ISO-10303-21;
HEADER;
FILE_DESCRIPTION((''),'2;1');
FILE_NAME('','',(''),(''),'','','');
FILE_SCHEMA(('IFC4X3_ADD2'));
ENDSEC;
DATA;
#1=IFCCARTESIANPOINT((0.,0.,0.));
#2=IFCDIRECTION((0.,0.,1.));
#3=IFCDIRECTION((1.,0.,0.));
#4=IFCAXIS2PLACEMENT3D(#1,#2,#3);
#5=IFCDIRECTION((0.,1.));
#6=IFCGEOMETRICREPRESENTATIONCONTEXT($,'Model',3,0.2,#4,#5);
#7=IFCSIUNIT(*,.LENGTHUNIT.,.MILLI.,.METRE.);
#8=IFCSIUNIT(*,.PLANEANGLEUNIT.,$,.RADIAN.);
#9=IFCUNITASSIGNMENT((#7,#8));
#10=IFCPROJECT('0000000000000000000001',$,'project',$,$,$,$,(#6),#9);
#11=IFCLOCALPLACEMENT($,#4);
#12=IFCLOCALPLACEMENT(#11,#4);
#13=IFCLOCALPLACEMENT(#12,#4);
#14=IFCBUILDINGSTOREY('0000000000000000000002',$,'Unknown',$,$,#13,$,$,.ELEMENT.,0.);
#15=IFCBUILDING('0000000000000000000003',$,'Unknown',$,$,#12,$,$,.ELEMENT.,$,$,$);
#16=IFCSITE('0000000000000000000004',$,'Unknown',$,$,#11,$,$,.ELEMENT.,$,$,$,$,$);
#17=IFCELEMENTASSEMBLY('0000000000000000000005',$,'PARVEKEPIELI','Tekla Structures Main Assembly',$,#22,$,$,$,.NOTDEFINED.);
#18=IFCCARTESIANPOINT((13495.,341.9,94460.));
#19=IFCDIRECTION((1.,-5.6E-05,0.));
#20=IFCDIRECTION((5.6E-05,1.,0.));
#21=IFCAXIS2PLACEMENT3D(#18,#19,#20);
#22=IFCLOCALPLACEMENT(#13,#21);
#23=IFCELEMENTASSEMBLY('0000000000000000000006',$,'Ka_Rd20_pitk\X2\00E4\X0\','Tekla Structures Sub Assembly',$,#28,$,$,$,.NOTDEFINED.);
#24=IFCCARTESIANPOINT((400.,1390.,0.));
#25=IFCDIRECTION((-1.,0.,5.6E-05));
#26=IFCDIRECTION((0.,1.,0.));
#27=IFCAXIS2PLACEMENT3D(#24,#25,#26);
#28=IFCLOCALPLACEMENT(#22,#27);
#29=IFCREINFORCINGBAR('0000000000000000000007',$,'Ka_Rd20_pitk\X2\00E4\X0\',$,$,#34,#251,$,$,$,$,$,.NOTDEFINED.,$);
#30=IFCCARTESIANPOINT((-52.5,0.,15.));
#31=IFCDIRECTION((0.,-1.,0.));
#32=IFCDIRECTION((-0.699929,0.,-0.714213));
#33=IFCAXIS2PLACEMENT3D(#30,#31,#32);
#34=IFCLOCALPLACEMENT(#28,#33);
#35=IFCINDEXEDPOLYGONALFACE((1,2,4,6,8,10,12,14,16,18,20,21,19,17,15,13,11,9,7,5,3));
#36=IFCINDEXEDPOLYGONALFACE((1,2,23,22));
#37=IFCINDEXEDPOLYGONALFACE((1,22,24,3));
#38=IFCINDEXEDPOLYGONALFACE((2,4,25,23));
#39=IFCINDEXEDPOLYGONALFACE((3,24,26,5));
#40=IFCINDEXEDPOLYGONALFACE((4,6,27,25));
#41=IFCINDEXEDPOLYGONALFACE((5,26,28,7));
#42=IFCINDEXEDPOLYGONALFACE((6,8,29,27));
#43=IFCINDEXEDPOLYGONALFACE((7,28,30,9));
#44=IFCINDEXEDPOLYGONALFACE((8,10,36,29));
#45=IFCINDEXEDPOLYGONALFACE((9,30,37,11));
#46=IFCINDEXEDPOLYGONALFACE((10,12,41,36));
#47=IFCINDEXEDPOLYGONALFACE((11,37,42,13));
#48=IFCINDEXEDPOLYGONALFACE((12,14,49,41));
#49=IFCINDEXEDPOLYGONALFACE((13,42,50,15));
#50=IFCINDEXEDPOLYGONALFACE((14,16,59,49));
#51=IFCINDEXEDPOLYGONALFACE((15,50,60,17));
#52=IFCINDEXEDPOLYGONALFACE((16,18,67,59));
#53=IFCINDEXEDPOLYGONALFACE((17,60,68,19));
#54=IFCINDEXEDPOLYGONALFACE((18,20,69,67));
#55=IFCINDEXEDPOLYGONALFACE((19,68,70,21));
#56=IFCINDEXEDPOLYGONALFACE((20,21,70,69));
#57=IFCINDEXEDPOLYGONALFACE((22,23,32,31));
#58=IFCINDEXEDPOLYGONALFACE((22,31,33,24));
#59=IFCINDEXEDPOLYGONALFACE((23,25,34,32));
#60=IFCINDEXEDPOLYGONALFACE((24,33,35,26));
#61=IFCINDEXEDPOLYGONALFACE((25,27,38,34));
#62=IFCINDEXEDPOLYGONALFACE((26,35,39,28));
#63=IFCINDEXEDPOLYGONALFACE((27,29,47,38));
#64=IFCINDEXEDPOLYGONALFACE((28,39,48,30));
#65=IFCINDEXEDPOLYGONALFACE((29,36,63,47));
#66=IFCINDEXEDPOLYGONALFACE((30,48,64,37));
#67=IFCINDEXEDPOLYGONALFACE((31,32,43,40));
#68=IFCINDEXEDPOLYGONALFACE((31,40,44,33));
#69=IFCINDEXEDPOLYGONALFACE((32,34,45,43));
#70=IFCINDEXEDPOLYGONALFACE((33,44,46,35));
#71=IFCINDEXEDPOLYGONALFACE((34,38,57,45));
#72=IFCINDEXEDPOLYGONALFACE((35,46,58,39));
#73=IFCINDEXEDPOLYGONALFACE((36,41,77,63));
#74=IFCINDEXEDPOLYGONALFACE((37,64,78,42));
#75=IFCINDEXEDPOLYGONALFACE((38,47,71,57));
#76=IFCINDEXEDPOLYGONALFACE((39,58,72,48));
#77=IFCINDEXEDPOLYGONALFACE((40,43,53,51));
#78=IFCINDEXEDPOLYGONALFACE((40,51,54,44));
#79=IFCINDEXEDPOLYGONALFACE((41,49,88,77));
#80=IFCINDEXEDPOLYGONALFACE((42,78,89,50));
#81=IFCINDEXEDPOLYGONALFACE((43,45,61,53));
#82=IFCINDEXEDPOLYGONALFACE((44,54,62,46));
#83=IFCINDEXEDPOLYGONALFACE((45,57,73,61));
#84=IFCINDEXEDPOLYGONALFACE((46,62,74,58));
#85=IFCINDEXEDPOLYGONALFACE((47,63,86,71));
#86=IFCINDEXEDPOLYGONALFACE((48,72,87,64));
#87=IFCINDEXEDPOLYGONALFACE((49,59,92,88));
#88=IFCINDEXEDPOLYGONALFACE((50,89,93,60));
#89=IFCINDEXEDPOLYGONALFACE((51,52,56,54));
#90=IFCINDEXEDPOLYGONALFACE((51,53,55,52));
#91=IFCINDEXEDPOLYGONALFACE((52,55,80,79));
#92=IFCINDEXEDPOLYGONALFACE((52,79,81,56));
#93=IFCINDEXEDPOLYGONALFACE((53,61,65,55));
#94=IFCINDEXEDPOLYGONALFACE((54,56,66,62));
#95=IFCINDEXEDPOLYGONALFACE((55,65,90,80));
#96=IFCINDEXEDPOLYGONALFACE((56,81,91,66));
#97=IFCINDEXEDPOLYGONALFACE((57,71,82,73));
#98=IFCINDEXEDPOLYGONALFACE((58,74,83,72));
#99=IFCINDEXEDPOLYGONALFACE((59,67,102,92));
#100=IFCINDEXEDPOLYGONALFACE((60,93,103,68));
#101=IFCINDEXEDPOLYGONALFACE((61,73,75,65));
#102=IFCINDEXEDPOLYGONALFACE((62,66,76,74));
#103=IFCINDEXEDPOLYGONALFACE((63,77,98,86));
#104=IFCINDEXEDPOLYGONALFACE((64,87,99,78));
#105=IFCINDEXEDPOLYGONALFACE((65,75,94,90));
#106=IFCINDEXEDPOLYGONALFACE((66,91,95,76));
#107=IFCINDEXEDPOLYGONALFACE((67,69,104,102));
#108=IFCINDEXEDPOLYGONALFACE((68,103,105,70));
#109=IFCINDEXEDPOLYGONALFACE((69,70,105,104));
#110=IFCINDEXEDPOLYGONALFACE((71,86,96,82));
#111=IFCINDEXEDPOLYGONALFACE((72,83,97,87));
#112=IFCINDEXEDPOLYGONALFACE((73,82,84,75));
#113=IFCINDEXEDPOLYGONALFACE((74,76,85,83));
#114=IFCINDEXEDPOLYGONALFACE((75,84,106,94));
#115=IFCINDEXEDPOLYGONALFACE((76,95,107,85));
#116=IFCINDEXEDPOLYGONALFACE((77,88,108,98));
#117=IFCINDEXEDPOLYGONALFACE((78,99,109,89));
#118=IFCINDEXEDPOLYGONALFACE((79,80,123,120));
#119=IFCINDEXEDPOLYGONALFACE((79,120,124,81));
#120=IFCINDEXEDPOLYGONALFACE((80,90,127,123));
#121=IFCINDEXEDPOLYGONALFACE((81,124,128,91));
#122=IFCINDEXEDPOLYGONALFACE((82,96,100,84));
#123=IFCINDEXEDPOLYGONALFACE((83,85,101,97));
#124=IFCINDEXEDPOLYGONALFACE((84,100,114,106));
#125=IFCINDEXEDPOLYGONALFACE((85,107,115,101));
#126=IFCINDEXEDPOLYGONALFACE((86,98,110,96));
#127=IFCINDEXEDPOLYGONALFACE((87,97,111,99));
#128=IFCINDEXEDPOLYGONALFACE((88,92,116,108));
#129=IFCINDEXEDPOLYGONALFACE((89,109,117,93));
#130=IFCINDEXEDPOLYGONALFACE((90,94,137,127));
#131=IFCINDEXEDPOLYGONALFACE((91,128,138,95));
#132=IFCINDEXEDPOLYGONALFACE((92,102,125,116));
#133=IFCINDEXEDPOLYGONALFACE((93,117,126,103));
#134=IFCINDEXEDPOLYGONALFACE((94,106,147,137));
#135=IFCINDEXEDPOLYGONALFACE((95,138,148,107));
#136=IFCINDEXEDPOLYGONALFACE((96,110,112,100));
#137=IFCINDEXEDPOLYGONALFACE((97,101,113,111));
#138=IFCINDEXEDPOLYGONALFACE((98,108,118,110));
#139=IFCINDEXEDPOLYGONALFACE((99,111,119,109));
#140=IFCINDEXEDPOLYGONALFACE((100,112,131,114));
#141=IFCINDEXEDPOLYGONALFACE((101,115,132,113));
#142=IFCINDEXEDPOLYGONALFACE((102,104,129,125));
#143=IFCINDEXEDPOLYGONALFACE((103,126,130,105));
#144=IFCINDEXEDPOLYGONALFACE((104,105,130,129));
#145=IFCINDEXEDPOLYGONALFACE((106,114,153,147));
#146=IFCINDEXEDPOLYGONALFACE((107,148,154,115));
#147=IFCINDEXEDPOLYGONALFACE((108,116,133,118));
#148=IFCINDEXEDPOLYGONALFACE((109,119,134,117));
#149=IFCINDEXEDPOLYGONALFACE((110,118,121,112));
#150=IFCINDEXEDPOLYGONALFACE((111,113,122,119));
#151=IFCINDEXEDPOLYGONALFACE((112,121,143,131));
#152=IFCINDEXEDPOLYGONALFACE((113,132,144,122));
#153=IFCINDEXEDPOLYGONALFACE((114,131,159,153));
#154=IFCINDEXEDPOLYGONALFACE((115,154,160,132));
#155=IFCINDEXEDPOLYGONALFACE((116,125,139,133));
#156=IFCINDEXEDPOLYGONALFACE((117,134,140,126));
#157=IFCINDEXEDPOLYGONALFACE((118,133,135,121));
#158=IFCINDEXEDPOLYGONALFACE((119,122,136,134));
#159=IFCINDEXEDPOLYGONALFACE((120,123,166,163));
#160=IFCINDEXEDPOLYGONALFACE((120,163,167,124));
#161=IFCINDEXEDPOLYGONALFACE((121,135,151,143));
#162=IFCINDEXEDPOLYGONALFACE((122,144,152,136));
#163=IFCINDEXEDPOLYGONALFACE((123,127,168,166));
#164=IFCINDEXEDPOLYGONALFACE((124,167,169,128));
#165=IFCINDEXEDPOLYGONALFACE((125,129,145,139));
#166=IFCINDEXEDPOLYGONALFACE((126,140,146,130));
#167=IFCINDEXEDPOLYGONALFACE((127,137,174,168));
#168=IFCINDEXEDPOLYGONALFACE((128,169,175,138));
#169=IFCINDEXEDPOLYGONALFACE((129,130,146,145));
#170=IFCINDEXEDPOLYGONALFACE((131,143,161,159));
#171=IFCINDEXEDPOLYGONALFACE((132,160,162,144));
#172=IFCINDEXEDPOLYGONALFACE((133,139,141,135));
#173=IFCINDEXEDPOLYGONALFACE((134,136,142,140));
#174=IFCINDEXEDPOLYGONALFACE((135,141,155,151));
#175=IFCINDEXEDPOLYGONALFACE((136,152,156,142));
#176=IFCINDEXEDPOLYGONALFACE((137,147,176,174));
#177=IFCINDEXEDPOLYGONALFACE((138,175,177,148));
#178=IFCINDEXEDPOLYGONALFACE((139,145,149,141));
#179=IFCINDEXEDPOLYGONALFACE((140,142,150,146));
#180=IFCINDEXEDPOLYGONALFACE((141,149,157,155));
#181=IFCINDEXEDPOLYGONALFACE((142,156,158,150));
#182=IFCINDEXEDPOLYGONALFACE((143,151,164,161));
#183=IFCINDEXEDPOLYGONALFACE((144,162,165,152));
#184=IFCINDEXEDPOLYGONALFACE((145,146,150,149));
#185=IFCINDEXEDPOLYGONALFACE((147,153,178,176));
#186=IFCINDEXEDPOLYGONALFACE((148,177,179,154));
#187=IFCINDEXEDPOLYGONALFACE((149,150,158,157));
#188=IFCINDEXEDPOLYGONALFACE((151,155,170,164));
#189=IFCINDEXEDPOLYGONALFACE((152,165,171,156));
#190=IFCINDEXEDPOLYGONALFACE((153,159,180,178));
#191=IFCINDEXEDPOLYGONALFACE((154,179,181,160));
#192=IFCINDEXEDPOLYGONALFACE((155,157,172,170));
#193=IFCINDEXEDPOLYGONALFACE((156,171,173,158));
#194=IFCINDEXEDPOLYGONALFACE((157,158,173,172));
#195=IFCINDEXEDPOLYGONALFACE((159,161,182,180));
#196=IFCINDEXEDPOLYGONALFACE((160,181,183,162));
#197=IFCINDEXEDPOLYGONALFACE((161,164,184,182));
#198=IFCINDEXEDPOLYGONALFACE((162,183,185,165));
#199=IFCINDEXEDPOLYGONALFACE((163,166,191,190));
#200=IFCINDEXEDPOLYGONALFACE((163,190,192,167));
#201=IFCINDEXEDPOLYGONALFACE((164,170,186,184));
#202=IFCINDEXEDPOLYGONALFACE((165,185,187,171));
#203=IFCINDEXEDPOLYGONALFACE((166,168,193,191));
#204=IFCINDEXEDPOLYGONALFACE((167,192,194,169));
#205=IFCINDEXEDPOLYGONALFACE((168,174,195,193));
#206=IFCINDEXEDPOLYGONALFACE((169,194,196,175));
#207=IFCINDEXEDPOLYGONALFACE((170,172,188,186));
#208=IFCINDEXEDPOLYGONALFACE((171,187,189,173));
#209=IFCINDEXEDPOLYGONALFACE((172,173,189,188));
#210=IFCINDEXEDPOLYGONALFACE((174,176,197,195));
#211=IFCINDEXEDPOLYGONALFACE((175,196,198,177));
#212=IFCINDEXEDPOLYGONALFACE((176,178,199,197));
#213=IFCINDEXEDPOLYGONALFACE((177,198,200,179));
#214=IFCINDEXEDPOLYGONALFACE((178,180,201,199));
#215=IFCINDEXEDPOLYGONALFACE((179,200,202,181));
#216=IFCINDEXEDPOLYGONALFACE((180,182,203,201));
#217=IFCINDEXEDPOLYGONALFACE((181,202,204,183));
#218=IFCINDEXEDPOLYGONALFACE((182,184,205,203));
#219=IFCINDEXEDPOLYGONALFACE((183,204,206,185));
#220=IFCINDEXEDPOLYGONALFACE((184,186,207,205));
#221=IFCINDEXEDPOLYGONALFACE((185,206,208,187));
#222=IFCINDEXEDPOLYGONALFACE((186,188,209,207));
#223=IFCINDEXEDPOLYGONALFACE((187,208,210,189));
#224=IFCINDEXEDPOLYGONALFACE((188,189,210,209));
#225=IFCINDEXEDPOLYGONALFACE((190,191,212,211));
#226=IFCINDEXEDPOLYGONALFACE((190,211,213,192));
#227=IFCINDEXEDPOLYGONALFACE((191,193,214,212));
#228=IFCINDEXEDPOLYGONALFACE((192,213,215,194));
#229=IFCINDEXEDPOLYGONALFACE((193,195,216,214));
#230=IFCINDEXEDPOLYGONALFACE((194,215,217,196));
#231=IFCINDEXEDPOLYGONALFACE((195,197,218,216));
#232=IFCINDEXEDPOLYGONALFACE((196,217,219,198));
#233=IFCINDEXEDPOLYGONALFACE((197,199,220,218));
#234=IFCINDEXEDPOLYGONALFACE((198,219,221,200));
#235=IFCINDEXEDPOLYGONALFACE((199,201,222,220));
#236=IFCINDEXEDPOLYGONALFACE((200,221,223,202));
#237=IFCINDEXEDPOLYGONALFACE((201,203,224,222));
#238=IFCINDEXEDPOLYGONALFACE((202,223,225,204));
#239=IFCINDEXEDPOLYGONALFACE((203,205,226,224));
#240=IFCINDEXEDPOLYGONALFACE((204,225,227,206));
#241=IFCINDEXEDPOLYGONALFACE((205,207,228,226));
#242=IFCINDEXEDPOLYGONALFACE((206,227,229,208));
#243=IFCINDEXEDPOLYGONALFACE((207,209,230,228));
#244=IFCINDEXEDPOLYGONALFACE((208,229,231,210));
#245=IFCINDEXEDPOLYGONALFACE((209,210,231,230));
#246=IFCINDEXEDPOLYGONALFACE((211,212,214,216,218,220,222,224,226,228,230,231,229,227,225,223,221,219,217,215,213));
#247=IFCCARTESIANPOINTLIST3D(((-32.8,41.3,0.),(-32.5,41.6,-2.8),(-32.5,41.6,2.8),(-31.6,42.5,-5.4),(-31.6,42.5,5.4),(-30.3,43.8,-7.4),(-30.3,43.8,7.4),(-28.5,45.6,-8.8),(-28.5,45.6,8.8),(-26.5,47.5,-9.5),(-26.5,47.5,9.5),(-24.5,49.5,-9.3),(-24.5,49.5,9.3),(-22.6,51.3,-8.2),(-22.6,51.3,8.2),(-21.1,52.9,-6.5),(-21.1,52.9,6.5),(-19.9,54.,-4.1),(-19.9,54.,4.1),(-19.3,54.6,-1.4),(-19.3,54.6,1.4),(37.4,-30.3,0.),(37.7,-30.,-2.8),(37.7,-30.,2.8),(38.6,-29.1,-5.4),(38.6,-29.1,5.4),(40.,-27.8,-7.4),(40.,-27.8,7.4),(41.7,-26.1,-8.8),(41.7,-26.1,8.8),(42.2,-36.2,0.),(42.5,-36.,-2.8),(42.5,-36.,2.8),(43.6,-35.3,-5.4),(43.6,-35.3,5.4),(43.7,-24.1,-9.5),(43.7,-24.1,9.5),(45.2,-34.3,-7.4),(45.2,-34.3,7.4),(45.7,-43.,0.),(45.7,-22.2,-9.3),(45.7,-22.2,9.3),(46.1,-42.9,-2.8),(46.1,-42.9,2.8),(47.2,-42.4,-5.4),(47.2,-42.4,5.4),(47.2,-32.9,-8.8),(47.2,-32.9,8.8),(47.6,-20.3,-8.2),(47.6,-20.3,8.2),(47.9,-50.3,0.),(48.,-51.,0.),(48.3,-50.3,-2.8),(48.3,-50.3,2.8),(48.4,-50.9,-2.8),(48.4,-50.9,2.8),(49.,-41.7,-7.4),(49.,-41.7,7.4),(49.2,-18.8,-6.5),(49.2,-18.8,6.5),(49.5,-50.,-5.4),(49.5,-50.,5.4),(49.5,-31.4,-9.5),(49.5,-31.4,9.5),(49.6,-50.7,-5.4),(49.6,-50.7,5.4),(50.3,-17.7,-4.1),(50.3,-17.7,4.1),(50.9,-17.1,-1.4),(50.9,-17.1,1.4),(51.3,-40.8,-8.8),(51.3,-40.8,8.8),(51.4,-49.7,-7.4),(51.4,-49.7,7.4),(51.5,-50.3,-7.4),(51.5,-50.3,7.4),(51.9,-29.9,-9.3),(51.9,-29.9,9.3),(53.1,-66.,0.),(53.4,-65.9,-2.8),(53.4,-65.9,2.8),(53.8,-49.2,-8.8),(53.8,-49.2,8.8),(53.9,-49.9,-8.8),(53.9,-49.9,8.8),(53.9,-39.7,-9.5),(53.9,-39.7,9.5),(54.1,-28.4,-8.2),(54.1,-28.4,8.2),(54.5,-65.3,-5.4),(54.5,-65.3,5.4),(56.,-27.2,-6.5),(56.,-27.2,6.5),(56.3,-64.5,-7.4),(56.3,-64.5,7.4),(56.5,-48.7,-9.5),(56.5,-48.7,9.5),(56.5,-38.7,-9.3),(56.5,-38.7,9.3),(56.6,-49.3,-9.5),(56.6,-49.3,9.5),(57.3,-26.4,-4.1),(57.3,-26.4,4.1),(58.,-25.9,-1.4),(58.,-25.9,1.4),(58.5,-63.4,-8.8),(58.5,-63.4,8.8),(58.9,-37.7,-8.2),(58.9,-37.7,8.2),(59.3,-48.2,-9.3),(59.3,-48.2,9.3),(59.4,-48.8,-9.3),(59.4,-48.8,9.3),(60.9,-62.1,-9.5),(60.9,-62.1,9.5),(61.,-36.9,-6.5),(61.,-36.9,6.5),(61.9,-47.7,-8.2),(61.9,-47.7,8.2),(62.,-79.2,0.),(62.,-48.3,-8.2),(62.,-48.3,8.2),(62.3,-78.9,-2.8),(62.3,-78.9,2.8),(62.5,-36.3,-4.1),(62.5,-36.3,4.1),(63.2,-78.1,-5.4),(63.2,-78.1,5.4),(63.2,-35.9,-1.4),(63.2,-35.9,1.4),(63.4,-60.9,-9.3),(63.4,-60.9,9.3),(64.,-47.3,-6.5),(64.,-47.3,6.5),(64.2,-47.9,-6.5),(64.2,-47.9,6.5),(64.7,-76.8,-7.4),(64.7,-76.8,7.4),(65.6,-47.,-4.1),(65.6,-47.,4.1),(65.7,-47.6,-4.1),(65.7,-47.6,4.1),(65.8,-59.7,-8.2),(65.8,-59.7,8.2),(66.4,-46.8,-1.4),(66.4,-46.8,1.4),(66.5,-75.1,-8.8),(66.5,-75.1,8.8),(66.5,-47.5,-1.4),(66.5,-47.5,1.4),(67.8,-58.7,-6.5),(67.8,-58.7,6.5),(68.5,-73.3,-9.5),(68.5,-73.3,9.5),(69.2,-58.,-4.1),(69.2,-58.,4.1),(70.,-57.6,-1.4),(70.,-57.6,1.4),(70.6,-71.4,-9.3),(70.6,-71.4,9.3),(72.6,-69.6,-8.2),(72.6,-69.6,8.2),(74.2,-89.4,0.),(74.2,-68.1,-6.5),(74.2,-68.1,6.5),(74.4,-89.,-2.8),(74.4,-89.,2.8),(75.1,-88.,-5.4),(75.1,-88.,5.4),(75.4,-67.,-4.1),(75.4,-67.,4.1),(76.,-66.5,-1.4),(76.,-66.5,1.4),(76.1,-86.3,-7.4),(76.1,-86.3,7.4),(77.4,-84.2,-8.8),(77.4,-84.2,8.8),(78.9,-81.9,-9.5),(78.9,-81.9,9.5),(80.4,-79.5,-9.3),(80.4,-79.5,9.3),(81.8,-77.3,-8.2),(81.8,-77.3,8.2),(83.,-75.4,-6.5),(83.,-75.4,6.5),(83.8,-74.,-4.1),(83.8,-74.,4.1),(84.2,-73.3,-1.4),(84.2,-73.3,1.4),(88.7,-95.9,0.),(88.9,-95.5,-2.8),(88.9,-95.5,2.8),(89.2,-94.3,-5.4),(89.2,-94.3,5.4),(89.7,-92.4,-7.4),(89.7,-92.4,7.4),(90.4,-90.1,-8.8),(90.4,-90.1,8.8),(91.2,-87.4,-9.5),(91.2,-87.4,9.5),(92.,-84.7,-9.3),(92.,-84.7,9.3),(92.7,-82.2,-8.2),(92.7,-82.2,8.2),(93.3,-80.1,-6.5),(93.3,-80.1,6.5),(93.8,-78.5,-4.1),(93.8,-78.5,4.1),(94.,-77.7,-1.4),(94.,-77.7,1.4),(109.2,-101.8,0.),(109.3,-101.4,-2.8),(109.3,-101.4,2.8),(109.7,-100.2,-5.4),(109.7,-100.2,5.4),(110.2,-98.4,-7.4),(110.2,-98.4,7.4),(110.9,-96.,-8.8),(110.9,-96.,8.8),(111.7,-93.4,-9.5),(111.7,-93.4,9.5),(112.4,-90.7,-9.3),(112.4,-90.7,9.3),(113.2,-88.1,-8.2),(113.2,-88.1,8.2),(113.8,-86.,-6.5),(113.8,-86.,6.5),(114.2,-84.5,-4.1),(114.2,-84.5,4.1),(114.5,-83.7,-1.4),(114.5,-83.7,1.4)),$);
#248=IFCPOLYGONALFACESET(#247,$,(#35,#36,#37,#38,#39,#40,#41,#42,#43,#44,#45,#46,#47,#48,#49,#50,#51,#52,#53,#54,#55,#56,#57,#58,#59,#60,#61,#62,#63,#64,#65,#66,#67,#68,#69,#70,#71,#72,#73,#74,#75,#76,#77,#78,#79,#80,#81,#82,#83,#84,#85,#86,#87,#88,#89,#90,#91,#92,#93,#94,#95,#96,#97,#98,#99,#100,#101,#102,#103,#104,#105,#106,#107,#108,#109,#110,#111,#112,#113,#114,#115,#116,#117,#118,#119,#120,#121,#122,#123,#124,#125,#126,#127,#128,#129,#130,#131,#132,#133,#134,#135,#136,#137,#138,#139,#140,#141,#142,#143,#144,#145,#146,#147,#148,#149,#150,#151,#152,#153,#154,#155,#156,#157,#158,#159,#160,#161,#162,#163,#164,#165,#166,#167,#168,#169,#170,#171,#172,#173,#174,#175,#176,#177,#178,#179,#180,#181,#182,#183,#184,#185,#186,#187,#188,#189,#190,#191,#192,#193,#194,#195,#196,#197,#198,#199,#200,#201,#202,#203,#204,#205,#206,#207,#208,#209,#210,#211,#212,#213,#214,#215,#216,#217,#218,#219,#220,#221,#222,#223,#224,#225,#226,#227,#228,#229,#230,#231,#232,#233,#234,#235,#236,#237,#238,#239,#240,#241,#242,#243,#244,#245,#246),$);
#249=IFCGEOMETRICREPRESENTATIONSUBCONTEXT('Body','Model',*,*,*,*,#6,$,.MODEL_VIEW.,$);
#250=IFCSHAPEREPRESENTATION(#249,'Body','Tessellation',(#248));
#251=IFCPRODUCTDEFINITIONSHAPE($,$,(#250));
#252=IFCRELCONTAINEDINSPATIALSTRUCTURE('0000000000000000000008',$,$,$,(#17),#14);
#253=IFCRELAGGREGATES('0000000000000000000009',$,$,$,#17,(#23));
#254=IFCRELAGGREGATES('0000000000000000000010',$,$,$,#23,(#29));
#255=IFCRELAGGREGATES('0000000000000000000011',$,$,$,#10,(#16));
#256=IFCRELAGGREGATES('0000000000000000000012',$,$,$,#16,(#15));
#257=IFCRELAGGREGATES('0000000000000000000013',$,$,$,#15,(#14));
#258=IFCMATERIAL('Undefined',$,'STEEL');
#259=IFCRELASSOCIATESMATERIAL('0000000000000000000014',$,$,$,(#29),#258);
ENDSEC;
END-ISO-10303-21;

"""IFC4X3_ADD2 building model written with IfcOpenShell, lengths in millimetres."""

from ifc_helpers import new_model, entity, si_unit, direction, frame, origin_with_axes, place, context, subcontext, project, spatial, material, element, aggregate, save


model = new_model("IFC4X3_ADD2")

# Units and contexts
model_context = context("Model", 3, precision=0.2, world=origin_with_axes(), true_north=direction((0.0, 1.0)))
body_context = subcontext(model_context, "Body", "Model", "MODEL_VIEW")
ifc_project = project(units=[si_unit("LENGTHUNIT", "METRE", prefix="MILLI"), si_unit("PLANEANGLEUNIT", "RADIAN")], contexts=[model_context])

# Site, building, storey
site_placement = place(None, origin_with_axes())
site = spatial("IfcSite", under=ifc_project, at=site_placement, Name="Unknown", CompositionType="ELEMENT")
building_placement = place(site_placement, origin_with_axes())
building = spatial("IfcBuilding", under=site, at=building_placement, Name="Unknown", CompositionType="ELEMENT")
storey_placement = place(building_placement, origin_with_axes())
storey = spatial("IfcBuildingStorey", under=building, at=storey_placement, Name="Unknown", CompositionType="ELEMENT", Elevation=0.0)

# Element assemblies
assembly_1_placement = place(storey_placement, frame((13495.0, 341.9, 94460.0), z_axis=(1.0, -0.000056, 0.0), x_axis=(0.000056, 1.0, 0.0)))
assembly_1 = element("IfcElementAssembly", 1, at=assembly_1_placement, inside=storey, Name="PARVEKEPIELI", Description="Tekla Structures Main Assembly", PredefinedType="NOTDEFINED")
assembly_2_placement = place(assembly_1_placement, frame((400.0, 1390.0, 0.0), z_axis=(-1.0, 0.0, 0.000056), x_axis=(0.0, 1.0, 0.0)))
assembly_2 = element("IfcElementAssembly", 2, at=assembly_2_placement, Name="Ka_Rd20_pitkä", Description="Tekla Structures Sub Assembly", PredefinedType="NOTDEFINED")

aggregate(assembly_1, [assembly_2])

# Reinforcing bar
ifc_material_1 = material(Name="Undefined", Category="STEEL")
reinforcing_bar_1_placement = place(assembly_2_placement, frame((-52.5, 0.0, 15.0), z_axis=(0.0, -1.0, 0.0), x_axis=(-0.699929, 0.0, -0.714213)))
reinforcing_bar_1 = element("IfcReinforcingBar", 3, at=reinforcing_bar_1_placement, material=ifc_material_1, Name="Ka_Rd20_pitkä", PredefinedType="NOTDEFINED", context=body_context, shape_type="AdvancedSweptSolid", body=[
    entity("IfcSweptDiskSolid", entity("IfcIndexedPolyCurve", entity("IfcCartesianPointList3D", [[-26.0, 48.0, 0.0], [44.2, -23.7, 0.0], [52.5, -35.1, 0.0], [57.2, -48.6, 0.0], [57.3, -49.2, 0.0], [69.1, -72.8, 0.0], [91.4, -86.7, 0.0], [111.9, -92.7, 0.0]]), [entity("IfcLineIndex", [1, 2]), entity("IfcArcIndex", [2, 3, 4]), entity("IfcLineIndex", [4, 5]), entity("IfcArcIndex", [5, 6, 7]), entity("IfcLineIndex", [7, 8])]), 9.5),
])
aggregate(assembly_2, [reinforcing_bar_1])

save(model, "model.ifc")
